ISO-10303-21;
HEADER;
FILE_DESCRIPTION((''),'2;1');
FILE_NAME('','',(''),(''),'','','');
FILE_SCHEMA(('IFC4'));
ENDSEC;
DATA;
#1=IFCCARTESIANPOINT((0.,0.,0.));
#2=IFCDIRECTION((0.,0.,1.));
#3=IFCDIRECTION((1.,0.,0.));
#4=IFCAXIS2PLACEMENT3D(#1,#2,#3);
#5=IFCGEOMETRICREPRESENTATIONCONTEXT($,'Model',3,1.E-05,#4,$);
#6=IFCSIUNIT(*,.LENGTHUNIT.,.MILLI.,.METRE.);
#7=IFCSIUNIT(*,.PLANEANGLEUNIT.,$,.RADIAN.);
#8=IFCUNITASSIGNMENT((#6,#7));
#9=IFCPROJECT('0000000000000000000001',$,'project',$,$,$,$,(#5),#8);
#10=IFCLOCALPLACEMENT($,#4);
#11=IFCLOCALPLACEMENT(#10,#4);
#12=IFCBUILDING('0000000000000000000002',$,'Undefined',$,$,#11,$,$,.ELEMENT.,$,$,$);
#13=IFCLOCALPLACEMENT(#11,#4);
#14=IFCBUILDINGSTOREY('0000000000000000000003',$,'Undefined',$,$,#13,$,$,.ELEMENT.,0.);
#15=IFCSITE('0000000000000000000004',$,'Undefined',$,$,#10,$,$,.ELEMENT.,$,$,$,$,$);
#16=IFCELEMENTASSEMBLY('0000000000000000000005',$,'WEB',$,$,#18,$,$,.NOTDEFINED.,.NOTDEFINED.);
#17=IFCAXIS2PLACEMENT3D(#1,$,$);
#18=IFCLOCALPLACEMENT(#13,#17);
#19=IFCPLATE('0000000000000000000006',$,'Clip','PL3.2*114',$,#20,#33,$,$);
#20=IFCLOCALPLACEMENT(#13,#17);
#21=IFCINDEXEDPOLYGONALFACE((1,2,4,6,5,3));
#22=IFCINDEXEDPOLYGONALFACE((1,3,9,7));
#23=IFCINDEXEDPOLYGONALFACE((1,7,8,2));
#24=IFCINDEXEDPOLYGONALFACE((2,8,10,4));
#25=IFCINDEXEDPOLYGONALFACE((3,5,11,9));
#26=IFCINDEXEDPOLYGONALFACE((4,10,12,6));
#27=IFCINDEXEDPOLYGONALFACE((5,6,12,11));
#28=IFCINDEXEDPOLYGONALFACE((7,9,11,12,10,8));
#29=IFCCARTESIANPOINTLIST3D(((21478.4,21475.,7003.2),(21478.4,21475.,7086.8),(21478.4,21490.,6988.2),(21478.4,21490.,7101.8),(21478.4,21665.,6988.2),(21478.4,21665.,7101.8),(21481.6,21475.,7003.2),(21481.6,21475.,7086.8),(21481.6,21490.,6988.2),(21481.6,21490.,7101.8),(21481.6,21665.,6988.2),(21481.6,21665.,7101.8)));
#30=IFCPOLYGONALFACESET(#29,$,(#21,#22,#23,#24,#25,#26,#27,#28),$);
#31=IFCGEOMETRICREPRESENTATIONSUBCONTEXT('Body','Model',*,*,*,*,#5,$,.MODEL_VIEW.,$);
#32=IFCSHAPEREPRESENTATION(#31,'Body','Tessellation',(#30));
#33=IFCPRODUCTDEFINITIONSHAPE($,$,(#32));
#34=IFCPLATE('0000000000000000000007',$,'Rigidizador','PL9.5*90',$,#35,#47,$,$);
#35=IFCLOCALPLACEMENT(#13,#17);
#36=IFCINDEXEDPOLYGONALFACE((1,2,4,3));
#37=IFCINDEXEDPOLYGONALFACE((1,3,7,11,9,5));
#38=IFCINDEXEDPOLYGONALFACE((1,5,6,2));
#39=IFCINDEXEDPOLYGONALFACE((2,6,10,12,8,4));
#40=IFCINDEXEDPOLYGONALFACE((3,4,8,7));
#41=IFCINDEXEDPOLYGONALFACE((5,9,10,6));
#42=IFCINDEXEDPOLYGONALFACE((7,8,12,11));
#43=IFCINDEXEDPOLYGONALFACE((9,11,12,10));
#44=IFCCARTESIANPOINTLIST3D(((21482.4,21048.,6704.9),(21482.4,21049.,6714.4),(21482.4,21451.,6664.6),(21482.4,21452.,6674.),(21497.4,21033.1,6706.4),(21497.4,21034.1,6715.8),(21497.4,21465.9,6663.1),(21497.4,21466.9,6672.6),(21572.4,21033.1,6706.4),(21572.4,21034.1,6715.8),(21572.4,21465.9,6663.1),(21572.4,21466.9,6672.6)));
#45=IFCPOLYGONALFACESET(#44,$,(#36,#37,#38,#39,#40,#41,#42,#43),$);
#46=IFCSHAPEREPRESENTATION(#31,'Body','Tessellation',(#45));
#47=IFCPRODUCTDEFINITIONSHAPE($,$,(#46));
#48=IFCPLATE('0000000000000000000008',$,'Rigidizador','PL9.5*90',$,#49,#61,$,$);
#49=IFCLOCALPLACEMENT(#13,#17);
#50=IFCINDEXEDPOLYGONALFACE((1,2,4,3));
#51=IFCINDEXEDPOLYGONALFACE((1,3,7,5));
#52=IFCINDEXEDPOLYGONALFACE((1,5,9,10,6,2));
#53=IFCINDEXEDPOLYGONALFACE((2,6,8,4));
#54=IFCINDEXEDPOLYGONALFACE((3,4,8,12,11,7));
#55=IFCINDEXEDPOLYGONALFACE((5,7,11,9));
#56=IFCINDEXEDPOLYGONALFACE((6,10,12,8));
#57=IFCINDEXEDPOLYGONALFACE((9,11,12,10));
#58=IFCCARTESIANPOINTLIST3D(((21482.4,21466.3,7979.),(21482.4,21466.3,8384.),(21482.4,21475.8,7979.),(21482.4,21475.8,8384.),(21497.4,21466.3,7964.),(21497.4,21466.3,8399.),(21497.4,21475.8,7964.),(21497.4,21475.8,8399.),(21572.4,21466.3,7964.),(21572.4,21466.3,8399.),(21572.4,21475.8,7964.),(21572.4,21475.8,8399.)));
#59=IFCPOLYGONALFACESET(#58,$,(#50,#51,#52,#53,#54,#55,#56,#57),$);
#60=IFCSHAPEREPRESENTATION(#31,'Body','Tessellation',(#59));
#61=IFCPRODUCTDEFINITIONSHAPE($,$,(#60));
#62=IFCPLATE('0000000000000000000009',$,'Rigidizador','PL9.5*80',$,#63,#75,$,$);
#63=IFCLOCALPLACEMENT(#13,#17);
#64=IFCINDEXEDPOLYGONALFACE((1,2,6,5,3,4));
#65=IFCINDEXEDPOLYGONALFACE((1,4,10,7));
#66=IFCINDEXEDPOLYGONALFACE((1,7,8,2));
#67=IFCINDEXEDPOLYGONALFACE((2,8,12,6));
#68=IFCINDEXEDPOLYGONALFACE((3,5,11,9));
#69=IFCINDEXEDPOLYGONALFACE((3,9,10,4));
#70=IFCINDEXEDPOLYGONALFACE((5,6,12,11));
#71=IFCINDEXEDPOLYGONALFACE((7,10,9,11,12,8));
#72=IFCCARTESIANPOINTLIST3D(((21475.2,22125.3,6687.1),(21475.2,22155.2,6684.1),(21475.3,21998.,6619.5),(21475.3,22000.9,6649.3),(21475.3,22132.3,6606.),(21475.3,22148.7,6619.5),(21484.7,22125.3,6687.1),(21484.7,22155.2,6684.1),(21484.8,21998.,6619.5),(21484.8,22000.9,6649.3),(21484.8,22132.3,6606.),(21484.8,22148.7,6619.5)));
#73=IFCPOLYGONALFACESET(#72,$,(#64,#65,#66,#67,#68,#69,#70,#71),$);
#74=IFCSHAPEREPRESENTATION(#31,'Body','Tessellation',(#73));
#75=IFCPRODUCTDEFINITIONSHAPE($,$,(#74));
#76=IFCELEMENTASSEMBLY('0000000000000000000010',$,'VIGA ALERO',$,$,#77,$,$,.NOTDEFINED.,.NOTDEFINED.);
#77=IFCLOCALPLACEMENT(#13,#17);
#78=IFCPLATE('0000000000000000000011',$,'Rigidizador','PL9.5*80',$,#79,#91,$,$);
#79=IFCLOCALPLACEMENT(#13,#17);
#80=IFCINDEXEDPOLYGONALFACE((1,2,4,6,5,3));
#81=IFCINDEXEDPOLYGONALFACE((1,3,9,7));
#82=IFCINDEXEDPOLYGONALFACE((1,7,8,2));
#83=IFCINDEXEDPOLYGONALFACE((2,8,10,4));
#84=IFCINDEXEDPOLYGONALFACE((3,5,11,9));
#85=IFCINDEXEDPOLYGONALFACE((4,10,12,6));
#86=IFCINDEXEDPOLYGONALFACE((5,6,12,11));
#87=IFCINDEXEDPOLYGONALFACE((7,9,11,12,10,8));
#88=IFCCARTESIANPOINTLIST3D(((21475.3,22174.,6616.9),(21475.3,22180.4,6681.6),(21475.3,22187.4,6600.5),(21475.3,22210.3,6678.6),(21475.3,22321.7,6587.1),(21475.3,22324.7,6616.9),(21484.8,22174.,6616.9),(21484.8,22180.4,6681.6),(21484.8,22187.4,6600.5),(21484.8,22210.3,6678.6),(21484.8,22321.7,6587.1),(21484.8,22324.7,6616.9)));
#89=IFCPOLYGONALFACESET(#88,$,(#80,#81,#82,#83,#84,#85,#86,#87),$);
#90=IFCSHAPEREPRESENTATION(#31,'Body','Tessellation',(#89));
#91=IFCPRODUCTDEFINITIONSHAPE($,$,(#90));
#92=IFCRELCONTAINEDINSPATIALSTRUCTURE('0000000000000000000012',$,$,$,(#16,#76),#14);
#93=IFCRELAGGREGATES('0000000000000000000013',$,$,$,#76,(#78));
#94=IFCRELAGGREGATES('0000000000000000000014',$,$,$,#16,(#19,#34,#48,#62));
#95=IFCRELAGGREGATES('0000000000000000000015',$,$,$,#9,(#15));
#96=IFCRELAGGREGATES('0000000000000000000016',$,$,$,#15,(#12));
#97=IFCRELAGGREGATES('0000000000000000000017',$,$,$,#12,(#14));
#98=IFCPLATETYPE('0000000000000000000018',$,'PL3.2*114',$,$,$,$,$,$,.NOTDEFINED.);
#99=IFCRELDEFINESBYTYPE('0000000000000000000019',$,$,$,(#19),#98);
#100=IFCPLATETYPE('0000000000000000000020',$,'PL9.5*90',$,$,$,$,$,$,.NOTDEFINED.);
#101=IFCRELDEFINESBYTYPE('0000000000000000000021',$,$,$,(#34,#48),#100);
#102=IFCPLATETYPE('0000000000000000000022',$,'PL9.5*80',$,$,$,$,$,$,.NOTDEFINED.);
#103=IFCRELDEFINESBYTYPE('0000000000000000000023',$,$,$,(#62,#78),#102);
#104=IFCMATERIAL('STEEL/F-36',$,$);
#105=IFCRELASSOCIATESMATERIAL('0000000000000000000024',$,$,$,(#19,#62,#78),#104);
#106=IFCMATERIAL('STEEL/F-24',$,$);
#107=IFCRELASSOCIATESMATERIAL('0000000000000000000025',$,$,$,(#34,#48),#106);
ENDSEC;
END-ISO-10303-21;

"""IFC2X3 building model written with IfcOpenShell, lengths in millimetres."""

from ifc_helpers import new_model, si_unit, frame, origin_with_axes, place, context, subcontext, project, spatial, polyline, outline, extrude, material, type_object, element, aggregate, save


model = new_model("IFC2X3")

# Units and contexts
model_context = context("Model", 3, precision=1e-05, world=origin_with_axes())
body_context = subcontext(model_context, "Body", "Model", "MODEL_VIEW")
ifc_project = project(units=[si_unit("LENGTHUNIT", "METRE", prefix="MILLI"), si_unit("PLANEANGLEUNIT", "RADIAN")], contexts=[model_context])

# Site, building, storey
site_placement = place(None, origin_with_axes())
site = spatial("IfcSite", under=ifc_project, at=site_placement, Name="Undefined", CompositionType="ELEMENT")
building_placement = place(site_placement, origin_with_axes())
building = spatial("IfcBuilding", under=site, at=building_placement, Name="Undefined", CompositionType="ELEMENT")
storey_placement = place(building_placement, origin_with_axes())
storey = spatial("IfcBuildingStorey", under=building, at=storey_placement, Name="Undefined", CompositionType="ELEMENT", Elevation=0.0)

# Element assembly, plates
assembly_1_placement = place(storey_placement, origin_with_axes())
assembly_1 = element("IfcElementAssembly", 1, at=assembly_1_placement, inside=storey, Name="WEB", AssemblyPlace="NOTDEFINED", PredefinedType="NOTDEFINED")
ifc_material_1 = material(Name="STEEL/F-36")
plate_type_1 = type_object("IfcPlateType", Name="PL3.2*114", PredefinedType="NOTDEFINED")
plate_1_placement = place(assembly_1_placement, frame((21480.0, 21665.0, 6988.2), z_axis=(1.0, 0.0, 0.0), x_axis=(0.0, -0.000147, 1.0)))
plate_1 = element("IfcPlate", 2, at=plate_1_placement, type_object=plate_type_1, material=ifc_material_1, Name="Clip", Description="PL3.2*114", context=body_context, shape_type="SweptSolid", body=[
    extrude(outline(polyline([(0.0, 0.0), (113.6, 0.0), (113.6, 175.0), (98.6, 190.0), (15.0, 190.0), (0.0, 175.0), (0.0, 0.0)])), frame((0.0, 0.0, -1.6), z_axis=(0.0, 0.0, 1.0), x_axis=(1.0, 0.0, 0.0)), (0.0, 0.0, 1.0), 3.2),
])
ifc_material_2 = material(Name="STEEL/F-24")
plate_type_2 = type_object("IfcPlateType", Name="PL9.5*90", PredefinedType="NOTDEFINED")
plate_2_placement = place(assembly_1_placement, frame((21572.4, 21466.4, 6667.8), z_axis=(0.0, 0.099511, 0.995036), x_axis=(-1.0, 0.0, 0.0)))
plate_2 = element("IfcPlate", 3, at=plate_2_placement, type_object=plate_type_2, material=ifc_material_2, Name="Rigidizador", Description="PL9.5*90", context=body_context, shape_type="SweptSolid", body=[
    extrude(outline(polyline([(0.0, 0.0), (75.0, 0.0), (90.0, 15.0), (90.0, 420.0), (75.0, 435.0), (0.0, 435.0), (0.0, 0.0)])), frame((0.0, 0.0, -4.7), z_axis=(0.0, 0.0, 1.0), x_axis=(1.0, 0.0, 0.0)), (0.0, 0.0, 1.0), 9.5),
])
plate_3_placement = place(assembly_1_placement, frame((21572.4, 21471.1, 7964.0), z_axis=(0.0, 1.0, 0.0), x_axis=(-1.0, 0.0, 0.0)))
plate_3 = element("IfcPlate", 4, at=plate_3_placement, type_object=plate_type_2, material=ifc_material_2, Name="Rigidizador", Description="PL9.5*90", context=body_context, shape_type="SweptSolid", body=[
    extrude(outline(polyline([(0.0, 0.0), (75.0, 0.0), (90.0, 15.0), (90.0, 420.0), (75.0, 435.0), (0.0, 435.0), (0.0, 0.0)])), frame((0.0, 0.0, -4.7), z_axis=(0.0, 0.0, 1.0), x_axis=(1.0, 0.0, 0.0)), (0.0, 0.0, 1.0), 9.5),
])
plate_type_3 = type_object("IfcPlateType", Name="PL9.5*80", PredefinedType="NOTDEFINED")
plate_4_placement = place(assembly_1_placement, frame((21480.0, 22155.2, 6684.1), z_axis=(-1.0, 0.0, 0.0), x_axis=(0.0, -0.099512, -0.995036)))
plate_4 = element("IfcPlate", 5, at=plate_4_placement, type_object=plate_type_3, material=ifc_material_1, Name="Rigidizador", Description="PL9.5*80", context=body_context, shape_type="SweptSolid", body=[
    extrude(outline(polyline([(0.0, 0.0), (65.0, 0.0), (80.0, 15.0), (80.0, 150.0), (50.0, 150.0), (0.0, 30.0), (0.0, 0.0)])), frame((0.0, 0.0, -4.7), z_axis=(0.0, 0.0, 1.0), x_axis=(1.0, 0.0, 0.0)), (0.0, 0.0, 1.0), 9.5),
])

# Element assembly, plate
assembly_2_placement = place(storey_placement, origin_with_axes())
assembly_2 = element("IfcElementAssembly", 6, at=assembly_2_placement, inside=storey, Name="VIGA ALERO", AssemblyPlace="NOTDEFINED", PredefinedType="NOTDEFINED")
plate_5_placement = place(assembly_2_placement, frame((21480.0, 22180.4, 6681.6), z_axis=(1.0, 0.0, 0.0), x_axis=(0.0, -0.099496, -0.995038)))
plate_5 = element("IfcPlate", 7, at=plate_5_placement, type_object=plate_type_3, material=ifc_material_1, Name="Rigidizador", Description="PL9.5*80", context=body_context, shape_type="SweptSolid", body=[
    extrude(outline(polyline([(0.0, 0.0), (65.0, 0.0), (80.0, 15.0), (80.0, 150.0), (50.0, 150.0), (0.0, 30.0), (0.0, 0.0)])), frame((0.0, 0.0, -4.7), z_axis=(0.0, 0.0, 1.0), x_axis=(1.0, 0.0, 0.0)), (0.0, 0.0, 1.0), 9.5),
])
aggregate(assembly_2, [plate_5])

aggregate(assembly_1, [plate_1, plate_2, plate_3, plate_4])

save(model, "model.ifc")
